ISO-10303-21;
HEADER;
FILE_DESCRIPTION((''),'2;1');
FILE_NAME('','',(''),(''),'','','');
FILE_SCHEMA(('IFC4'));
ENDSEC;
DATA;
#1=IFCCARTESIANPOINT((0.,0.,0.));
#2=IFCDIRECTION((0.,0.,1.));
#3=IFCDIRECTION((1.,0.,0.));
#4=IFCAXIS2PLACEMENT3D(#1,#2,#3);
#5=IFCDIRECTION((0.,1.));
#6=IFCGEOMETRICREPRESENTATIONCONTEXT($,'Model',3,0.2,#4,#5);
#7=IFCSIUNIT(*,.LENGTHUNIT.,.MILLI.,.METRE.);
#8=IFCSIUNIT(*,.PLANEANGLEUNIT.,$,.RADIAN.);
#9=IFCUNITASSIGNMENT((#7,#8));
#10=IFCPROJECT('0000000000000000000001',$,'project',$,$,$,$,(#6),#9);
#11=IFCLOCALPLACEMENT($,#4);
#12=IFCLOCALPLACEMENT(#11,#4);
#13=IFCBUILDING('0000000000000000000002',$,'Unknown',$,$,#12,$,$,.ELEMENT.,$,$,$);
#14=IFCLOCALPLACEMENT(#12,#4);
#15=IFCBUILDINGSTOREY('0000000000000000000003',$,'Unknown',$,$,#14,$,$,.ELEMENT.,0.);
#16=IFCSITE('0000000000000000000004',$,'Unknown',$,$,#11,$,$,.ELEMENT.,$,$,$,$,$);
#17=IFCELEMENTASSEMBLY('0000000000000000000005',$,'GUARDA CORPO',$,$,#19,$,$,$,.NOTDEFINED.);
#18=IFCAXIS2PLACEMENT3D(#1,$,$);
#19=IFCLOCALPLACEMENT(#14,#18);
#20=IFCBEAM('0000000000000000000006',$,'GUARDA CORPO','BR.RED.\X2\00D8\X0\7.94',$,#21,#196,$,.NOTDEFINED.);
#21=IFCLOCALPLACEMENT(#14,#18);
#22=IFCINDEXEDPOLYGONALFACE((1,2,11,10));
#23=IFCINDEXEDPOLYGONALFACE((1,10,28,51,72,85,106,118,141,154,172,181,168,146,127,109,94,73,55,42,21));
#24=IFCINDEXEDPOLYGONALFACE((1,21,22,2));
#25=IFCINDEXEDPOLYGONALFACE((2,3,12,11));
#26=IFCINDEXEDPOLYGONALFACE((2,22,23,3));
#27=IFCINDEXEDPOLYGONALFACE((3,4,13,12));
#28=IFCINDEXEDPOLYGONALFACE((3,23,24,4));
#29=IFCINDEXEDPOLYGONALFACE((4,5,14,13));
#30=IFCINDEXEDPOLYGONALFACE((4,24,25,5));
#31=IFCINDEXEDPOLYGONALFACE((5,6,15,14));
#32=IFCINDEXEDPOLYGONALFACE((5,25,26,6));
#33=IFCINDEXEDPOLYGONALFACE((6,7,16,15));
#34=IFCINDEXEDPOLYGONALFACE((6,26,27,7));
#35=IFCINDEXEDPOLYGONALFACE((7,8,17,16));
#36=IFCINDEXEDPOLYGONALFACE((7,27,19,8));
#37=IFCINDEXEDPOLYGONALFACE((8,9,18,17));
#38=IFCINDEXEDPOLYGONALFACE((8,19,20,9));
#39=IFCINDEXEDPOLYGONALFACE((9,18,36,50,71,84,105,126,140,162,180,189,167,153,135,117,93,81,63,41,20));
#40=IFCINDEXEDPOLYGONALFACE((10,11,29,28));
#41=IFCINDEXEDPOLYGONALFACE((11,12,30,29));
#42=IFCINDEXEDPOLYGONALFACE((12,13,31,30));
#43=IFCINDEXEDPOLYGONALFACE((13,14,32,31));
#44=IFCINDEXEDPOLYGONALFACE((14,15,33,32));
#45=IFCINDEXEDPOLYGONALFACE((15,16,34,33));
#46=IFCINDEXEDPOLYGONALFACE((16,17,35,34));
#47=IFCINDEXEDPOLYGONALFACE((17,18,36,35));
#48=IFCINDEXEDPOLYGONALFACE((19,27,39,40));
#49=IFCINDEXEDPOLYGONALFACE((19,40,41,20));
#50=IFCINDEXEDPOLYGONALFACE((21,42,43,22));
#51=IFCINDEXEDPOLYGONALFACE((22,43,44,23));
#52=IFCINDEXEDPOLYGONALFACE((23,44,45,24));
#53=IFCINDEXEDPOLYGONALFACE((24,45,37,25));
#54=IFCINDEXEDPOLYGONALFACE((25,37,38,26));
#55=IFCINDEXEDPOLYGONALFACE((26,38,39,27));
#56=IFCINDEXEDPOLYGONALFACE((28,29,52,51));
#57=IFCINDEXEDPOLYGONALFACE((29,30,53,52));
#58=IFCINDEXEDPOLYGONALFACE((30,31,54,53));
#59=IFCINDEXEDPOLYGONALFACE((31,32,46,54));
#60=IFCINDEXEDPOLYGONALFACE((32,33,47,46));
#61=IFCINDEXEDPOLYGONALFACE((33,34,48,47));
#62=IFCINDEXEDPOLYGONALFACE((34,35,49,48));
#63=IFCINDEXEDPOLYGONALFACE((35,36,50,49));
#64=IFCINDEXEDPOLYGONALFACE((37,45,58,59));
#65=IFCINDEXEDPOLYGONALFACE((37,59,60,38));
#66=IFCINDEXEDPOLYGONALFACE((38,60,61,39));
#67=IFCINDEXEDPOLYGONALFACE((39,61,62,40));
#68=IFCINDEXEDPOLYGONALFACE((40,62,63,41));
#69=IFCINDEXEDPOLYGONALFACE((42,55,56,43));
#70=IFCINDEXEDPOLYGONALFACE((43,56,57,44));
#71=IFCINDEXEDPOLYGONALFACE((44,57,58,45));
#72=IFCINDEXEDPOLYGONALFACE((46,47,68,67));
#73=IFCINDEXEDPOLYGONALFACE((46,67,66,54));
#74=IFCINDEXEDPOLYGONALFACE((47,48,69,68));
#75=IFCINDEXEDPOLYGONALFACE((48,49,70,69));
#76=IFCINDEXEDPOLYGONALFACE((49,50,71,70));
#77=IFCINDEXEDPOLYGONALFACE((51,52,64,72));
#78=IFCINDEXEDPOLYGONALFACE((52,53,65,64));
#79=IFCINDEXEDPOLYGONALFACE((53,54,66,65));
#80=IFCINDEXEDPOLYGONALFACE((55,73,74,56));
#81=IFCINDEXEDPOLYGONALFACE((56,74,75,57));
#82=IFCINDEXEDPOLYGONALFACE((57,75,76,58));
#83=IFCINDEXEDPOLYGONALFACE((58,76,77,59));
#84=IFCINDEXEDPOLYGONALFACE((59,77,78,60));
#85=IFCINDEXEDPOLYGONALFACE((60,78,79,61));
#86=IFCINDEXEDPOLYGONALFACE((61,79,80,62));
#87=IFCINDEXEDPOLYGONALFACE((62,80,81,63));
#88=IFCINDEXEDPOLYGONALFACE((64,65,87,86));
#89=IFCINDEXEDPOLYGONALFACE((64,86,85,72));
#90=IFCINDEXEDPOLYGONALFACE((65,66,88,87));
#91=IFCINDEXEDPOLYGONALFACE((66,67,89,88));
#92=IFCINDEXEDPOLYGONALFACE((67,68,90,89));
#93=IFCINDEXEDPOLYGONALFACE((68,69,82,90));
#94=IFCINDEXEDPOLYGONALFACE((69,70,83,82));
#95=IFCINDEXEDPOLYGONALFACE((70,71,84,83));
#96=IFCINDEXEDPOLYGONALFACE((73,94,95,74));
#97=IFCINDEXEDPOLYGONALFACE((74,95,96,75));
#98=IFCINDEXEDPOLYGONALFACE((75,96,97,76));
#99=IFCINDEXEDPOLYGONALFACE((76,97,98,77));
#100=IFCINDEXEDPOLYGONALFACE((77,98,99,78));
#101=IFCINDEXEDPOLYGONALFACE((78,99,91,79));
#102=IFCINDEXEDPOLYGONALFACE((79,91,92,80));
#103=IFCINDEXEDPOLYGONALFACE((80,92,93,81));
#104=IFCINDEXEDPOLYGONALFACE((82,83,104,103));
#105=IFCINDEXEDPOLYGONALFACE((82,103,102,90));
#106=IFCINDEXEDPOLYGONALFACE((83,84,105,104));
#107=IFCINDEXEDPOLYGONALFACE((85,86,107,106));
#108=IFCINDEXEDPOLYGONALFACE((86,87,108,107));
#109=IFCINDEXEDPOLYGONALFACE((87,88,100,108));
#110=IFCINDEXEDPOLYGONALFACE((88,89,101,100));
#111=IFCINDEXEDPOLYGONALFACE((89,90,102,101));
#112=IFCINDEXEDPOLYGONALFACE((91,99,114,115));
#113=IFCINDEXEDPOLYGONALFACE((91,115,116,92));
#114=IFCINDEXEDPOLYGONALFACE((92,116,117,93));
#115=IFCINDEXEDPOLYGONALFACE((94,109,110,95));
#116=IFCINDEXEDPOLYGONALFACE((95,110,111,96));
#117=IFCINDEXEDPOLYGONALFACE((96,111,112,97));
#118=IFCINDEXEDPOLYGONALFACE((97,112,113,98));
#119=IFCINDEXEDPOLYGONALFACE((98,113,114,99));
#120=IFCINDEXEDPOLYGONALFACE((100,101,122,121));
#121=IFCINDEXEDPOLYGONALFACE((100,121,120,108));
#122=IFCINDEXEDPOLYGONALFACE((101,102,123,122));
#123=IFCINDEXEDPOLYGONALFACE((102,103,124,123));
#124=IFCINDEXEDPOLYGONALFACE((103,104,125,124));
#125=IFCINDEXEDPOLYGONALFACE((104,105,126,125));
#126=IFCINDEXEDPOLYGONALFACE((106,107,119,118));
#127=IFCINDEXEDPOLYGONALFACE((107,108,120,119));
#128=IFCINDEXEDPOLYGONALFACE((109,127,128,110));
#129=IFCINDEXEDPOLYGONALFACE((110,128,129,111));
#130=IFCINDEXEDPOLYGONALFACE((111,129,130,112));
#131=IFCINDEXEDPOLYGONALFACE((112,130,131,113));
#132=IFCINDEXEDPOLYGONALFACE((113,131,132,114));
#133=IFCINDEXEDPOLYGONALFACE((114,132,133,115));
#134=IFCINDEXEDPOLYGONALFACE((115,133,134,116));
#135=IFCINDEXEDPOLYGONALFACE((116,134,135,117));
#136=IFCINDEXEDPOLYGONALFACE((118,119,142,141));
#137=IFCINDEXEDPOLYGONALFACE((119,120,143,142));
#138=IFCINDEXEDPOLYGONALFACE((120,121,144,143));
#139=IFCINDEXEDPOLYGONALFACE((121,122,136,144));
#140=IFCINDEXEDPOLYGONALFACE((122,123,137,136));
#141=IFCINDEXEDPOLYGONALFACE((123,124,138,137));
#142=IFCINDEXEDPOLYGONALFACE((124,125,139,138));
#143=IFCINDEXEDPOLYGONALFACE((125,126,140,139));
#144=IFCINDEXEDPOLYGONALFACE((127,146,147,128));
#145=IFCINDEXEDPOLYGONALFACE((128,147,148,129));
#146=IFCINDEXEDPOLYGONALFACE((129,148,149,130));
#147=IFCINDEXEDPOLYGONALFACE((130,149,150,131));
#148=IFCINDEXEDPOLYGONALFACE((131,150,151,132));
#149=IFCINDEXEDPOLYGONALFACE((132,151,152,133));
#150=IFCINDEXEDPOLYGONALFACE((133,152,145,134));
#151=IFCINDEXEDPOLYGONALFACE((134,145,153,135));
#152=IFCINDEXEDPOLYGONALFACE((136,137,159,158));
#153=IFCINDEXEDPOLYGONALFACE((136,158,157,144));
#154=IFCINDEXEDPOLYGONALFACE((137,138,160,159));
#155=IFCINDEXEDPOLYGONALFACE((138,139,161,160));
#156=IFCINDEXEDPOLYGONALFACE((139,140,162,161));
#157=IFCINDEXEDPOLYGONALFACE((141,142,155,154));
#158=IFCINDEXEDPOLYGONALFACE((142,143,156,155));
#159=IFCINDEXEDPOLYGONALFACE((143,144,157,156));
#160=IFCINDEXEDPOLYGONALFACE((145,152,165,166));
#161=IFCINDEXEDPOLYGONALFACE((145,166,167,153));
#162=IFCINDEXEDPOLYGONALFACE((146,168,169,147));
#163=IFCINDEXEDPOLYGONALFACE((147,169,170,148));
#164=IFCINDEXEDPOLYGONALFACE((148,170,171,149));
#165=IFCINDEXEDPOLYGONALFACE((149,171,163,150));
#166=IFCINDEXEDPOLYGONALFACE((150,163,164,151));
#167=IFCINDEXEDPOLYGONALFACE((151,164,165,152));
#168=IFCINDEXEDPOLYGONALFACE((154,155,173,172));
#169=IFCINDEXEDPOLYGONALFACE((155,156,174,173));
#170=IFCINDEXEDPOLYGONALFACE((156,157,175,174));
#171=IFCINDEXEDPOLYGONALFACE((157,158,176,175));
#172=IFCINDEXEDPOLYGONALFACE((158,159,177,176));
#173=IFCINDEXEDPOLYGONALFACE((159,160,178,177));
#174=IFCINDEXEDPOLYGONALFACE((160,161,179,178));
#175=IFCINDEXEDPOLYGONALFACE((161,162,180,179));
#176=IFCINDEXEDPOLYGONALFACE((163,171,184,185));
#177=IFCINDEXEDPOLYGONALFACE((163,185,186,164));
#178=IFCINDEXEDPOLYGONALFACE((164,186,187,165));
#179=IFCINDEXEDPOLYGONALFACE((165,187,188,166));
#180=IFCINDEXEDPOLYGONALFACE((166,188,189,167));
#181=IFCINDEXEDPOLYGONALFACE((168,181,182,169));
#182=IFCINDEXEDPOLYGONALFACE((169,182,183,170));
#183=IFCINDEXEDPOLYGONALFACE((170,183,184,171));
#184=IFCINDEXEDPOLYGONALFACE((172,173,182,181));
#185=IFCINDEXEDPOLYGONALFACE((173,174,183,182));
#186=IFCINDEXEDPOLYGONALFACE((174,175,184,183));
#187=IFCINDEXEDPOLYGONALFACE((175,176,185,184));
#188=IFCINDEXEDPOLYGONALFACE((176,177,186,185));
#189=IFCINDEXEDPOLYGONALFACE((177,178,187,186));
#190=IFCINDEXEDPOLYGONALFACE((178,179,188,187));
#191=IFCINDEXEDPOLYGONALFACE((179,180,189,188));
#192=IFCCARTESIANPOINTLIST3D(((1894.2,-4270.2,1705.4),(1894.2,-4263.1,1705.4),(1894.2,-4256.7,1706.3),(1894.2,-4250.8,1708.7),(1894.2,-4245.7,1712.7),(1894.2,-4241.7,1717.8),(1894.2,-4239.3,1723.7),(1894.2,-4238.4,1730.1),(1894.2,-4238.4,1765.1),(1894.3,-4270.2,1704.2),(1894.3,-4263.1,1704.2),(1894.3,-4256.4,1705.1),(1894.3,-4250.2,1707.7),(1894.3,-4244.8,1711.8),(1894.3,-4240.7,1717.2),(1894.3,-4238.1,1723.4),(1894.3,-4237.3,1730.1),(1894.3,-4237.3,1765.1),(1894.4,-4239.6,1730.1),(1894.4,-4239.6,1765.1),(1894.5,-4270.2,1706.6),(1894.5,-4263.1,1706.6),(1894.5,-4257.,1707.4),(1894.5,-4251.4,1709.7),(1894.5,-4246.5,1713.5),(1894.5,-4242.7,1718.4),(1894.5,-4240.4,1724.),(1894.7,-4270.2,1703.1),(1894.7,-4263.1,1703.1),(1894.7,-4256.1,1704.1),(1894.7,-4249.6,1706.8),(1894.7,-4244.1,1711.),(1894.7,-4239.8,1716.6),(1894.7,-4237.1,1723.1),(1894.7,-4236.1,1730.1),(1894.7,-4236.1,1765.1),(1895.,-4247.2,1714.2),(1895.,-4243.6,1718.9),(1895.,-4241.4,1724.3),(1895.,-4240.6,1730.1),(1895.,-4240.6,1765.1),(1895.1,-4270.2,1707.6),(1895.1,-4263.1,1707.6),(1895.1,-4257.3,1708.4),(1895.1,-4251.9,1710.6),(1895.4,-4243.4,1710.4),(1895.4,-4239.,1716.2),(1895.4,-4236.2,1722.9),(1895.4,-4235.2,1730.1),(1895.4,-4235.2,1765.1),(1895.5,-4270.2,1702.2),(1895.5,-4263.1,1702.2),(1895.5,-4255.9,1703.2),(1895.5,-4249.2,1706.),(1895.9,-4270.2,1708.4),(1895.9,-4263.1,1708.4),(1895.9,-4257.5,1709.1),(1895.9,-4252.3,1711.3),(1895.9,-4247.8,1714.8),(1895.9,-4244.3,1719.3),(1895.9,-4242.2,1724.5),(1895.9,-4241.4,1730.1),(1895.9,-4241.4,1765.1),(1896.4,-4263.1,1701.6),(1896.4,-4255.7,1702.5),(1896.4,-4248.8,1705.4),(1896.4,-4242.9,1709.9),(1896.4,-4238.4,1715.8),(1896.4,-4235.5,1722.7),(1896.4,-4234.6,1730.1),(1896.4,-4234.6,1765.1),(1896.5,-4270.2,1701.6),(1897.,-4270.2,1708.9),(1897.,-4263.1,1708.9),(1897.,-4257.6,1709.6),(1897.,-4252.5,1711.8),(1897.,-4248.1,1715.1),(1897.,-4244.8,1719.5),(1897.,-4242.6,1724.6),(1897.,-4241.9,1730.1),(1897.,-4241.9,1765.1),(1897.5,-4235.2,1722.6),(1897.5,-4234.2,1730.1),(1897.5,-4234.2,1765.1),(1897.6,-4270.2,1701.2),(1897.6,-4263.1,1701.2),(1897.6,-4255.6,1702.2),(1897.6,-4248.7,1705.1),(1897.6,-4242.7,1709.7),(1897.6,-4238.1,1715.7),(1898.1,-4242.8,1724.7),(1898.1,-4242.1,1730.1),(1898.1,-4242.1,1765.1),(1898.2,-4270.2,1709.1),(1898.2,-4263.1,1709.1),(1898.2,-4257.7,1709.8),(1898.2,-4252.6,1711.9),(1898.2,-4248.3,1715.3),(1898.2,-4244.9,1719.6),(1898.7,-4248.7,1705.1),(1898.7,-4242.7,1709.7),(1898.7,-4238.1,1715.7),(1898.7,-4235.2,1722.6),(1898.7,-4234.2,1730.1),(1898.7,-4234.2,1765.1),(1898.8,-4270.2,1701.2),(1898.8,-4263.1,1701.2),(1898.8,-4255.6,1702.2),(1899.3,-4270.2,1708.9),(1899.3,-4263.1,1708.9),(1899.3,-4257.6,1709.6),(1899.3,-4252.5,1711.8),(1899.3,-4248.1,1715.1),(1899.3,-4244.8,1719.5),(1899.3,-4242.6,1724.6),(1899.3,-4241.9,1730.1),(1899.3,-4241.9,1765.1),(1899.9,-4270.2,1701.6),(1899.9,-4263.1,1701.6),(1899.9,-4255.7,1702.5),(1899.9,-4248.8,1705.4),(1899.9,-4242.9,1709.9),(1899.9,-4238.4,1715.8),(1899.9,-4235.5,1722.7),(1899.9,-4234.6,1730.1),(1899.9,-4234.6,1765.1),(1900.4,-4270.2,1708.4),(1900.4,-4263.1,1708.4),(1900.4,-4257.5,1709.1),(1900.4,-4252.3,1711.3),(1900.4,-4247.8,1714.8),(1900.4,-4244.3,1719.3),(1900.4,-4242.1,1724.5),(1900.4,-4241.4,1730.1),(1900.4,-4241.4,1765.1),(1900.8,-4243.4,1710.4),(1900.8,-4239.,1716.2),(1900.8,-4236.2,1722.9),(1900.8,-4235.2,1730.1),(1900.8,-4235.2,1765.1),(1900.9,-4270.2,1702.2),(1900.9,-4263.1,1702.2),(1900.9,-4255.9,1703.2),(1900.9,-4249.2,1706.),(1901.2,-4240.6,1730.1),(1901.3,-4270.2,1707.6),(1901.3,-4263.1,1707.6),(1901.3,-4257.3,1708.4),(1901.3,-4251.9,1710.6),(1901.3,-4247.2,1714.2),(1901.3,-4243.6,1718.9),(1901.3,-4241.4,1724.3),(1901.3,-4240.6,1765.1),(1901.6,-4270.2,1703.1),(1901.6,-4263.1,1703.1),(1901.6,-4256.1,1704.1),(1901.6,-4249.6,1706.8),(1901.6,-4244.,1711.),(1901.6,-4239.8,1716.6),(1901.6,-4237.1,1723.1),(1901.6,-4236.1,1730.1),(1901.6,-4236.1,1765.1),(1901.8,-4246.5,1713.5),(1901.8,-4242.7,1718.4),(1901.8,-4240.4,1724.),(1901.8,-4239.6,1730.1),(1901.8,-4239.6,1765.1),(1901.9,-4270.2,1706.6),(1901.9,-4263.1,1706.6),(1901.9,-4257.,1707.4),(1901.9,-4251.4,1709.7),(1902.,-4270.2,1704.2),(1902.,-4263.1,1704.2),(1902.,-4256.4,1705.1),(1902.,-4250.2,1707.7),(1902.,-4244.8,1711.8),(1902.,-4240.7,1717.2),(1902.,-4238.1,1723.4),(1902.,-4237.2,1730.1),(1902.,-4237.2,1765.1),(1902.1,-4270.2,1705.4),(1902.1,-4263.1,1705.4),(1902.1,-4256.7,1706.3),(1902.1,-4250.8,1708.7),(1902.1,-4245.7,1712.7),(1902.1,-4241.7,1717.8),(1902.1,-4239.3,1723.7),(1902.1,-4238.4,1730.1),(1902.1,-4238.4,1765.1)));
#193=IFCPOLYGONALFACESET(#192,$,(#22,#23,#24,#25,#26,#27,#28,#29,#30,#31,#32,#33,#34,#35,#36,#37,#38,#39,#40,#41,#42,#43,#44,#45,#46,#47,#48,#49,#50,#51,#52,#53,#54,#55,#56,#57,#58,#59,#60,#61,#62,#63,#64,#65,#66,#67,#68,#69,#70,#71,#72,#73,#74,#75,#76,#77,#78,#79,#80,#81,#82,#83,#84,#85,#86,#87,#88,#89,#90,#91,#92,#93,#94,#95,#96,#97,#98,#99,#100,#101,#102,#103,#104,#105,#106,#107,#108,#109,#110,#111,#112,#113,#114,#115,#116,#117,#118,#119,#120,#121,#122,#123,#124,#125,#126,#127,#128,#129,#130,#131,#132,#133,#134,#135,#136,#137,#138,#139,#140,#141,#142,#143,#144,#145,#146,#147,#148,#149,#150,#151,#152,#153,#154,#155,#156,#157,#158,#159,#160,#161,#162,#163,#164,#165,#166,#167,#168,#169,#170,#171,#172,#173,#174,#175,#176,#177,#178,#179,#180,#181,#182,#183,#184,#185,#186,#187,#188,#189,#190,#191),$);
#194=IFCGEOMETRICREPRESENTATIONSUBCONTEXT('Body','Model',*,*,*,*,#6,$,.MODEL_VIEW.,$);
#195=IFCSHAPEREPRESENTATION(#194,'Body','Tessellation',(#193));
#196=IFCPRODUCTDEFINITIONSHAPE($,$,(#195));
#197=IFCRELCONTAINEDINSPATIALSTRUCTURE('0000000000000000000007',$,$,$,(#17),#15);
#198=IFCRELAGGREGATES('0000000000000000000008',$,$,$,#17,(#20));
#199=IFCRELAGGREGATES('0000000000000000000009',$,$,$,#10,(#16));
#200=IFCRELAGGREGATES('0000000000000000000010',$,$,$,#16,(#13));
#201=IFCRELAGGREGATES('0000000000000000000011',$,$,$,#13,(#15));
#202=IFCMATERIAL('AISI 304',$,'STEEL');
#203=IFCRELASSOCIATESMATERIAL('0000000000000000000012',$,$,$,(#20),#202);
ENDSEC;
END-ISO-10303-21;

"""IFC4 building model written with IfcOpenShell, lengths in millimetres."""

from ifc_helpers import new_model, entity, si_unit, direction, frame, origin_with_axes, place, context, subcontext, project, spatial, material, element, aggregate, save


model = new_model("IFC4")

# Units and contexts
model_context = context("Model", 3, precision=0.2, world=origin_with_axes(), true_north=direction((0.0, 1.0)))
body_context = subcontext(model_context, "Body", "Model", "MODEL_VIEW")
ifc_project = project(units=[si_unit("LENGTHUNIT", "METRE", prefix="MILLI"), si_unit("PLANEANGLEUNIT", "RADIAN")], contexts=[model_context])

# Site, building, storey
site_placement = place(None, origin_with_axes())
site = spatial("IfcSite", under=ifc_project, at=site_placement, Name="Unknown", CompositionType="ELEMENT")
building_placement = place(site_placement, origin_with_axes())
building = spatial("IfcBuilding", under=site, at=building_placement, Name="Unknown", CompositionType="ELEMENT")
storey_placement = place(building_placement, origin_with_axes())
storey = spatial("IfcBuildingStorey", under=building, at=storey_placement, Name="Unknown", CompositionType="ELEMENT", Elevation=0.0)

# Element assembly
assembly_1_placement = place(storey_placement, frame((833.2, -4289.3, 1615.0), z_axis=(-0.000512, 1.0, -0.000003), x_axis=(0.000003, 0.000003, 1.0)))
assembly_1 = element("IfcElementAssembly", 1, at=assembly_1_placement, inside=storey, Name="GUARDA CORPO", PredefinedType="NOTDEFINED")
ifc_material_1 = material(Name="AISI 304", Category="STEEL")

# Beam
beam_1_placement = place(assembly_1_placement, frame((150.1, 1065.0, 50.6), z_axis=(-0.000003, 0.000512, -1.0), x_axis=(-1.0, 0.0, 0.000003)))
beam_1 = element("IfcBeam", 2, at=beam_1_placement, material=ifc_material_1, Name="GUARDA CORPO", Description="BR.RED.Ø7.94", PredefinedType="NOTDEFINED", context=body_context, shape_type="SolidModel", body=[
    entity("IfcSweptDiskSolid", entity("IfcIndexedPolyCurve", entity("IfcCartesianPointList3D", [[0.0, 0.0, 0.0], [35.0, 0.0, 0.0], [52.7, 0.0, 7.3], [60.0, 0.0, 25.0], [60.0, 0.0, 32.1]]), [entity("IfcLineIndex", [1, 2]), entity("IfcArcIndex", [2, 3, 4]), entity("IfcLineIndex", [4, 5])]), 4.0),
])

aggregate(assembly_1, [beam_1])

save(model, "model.ifc")
